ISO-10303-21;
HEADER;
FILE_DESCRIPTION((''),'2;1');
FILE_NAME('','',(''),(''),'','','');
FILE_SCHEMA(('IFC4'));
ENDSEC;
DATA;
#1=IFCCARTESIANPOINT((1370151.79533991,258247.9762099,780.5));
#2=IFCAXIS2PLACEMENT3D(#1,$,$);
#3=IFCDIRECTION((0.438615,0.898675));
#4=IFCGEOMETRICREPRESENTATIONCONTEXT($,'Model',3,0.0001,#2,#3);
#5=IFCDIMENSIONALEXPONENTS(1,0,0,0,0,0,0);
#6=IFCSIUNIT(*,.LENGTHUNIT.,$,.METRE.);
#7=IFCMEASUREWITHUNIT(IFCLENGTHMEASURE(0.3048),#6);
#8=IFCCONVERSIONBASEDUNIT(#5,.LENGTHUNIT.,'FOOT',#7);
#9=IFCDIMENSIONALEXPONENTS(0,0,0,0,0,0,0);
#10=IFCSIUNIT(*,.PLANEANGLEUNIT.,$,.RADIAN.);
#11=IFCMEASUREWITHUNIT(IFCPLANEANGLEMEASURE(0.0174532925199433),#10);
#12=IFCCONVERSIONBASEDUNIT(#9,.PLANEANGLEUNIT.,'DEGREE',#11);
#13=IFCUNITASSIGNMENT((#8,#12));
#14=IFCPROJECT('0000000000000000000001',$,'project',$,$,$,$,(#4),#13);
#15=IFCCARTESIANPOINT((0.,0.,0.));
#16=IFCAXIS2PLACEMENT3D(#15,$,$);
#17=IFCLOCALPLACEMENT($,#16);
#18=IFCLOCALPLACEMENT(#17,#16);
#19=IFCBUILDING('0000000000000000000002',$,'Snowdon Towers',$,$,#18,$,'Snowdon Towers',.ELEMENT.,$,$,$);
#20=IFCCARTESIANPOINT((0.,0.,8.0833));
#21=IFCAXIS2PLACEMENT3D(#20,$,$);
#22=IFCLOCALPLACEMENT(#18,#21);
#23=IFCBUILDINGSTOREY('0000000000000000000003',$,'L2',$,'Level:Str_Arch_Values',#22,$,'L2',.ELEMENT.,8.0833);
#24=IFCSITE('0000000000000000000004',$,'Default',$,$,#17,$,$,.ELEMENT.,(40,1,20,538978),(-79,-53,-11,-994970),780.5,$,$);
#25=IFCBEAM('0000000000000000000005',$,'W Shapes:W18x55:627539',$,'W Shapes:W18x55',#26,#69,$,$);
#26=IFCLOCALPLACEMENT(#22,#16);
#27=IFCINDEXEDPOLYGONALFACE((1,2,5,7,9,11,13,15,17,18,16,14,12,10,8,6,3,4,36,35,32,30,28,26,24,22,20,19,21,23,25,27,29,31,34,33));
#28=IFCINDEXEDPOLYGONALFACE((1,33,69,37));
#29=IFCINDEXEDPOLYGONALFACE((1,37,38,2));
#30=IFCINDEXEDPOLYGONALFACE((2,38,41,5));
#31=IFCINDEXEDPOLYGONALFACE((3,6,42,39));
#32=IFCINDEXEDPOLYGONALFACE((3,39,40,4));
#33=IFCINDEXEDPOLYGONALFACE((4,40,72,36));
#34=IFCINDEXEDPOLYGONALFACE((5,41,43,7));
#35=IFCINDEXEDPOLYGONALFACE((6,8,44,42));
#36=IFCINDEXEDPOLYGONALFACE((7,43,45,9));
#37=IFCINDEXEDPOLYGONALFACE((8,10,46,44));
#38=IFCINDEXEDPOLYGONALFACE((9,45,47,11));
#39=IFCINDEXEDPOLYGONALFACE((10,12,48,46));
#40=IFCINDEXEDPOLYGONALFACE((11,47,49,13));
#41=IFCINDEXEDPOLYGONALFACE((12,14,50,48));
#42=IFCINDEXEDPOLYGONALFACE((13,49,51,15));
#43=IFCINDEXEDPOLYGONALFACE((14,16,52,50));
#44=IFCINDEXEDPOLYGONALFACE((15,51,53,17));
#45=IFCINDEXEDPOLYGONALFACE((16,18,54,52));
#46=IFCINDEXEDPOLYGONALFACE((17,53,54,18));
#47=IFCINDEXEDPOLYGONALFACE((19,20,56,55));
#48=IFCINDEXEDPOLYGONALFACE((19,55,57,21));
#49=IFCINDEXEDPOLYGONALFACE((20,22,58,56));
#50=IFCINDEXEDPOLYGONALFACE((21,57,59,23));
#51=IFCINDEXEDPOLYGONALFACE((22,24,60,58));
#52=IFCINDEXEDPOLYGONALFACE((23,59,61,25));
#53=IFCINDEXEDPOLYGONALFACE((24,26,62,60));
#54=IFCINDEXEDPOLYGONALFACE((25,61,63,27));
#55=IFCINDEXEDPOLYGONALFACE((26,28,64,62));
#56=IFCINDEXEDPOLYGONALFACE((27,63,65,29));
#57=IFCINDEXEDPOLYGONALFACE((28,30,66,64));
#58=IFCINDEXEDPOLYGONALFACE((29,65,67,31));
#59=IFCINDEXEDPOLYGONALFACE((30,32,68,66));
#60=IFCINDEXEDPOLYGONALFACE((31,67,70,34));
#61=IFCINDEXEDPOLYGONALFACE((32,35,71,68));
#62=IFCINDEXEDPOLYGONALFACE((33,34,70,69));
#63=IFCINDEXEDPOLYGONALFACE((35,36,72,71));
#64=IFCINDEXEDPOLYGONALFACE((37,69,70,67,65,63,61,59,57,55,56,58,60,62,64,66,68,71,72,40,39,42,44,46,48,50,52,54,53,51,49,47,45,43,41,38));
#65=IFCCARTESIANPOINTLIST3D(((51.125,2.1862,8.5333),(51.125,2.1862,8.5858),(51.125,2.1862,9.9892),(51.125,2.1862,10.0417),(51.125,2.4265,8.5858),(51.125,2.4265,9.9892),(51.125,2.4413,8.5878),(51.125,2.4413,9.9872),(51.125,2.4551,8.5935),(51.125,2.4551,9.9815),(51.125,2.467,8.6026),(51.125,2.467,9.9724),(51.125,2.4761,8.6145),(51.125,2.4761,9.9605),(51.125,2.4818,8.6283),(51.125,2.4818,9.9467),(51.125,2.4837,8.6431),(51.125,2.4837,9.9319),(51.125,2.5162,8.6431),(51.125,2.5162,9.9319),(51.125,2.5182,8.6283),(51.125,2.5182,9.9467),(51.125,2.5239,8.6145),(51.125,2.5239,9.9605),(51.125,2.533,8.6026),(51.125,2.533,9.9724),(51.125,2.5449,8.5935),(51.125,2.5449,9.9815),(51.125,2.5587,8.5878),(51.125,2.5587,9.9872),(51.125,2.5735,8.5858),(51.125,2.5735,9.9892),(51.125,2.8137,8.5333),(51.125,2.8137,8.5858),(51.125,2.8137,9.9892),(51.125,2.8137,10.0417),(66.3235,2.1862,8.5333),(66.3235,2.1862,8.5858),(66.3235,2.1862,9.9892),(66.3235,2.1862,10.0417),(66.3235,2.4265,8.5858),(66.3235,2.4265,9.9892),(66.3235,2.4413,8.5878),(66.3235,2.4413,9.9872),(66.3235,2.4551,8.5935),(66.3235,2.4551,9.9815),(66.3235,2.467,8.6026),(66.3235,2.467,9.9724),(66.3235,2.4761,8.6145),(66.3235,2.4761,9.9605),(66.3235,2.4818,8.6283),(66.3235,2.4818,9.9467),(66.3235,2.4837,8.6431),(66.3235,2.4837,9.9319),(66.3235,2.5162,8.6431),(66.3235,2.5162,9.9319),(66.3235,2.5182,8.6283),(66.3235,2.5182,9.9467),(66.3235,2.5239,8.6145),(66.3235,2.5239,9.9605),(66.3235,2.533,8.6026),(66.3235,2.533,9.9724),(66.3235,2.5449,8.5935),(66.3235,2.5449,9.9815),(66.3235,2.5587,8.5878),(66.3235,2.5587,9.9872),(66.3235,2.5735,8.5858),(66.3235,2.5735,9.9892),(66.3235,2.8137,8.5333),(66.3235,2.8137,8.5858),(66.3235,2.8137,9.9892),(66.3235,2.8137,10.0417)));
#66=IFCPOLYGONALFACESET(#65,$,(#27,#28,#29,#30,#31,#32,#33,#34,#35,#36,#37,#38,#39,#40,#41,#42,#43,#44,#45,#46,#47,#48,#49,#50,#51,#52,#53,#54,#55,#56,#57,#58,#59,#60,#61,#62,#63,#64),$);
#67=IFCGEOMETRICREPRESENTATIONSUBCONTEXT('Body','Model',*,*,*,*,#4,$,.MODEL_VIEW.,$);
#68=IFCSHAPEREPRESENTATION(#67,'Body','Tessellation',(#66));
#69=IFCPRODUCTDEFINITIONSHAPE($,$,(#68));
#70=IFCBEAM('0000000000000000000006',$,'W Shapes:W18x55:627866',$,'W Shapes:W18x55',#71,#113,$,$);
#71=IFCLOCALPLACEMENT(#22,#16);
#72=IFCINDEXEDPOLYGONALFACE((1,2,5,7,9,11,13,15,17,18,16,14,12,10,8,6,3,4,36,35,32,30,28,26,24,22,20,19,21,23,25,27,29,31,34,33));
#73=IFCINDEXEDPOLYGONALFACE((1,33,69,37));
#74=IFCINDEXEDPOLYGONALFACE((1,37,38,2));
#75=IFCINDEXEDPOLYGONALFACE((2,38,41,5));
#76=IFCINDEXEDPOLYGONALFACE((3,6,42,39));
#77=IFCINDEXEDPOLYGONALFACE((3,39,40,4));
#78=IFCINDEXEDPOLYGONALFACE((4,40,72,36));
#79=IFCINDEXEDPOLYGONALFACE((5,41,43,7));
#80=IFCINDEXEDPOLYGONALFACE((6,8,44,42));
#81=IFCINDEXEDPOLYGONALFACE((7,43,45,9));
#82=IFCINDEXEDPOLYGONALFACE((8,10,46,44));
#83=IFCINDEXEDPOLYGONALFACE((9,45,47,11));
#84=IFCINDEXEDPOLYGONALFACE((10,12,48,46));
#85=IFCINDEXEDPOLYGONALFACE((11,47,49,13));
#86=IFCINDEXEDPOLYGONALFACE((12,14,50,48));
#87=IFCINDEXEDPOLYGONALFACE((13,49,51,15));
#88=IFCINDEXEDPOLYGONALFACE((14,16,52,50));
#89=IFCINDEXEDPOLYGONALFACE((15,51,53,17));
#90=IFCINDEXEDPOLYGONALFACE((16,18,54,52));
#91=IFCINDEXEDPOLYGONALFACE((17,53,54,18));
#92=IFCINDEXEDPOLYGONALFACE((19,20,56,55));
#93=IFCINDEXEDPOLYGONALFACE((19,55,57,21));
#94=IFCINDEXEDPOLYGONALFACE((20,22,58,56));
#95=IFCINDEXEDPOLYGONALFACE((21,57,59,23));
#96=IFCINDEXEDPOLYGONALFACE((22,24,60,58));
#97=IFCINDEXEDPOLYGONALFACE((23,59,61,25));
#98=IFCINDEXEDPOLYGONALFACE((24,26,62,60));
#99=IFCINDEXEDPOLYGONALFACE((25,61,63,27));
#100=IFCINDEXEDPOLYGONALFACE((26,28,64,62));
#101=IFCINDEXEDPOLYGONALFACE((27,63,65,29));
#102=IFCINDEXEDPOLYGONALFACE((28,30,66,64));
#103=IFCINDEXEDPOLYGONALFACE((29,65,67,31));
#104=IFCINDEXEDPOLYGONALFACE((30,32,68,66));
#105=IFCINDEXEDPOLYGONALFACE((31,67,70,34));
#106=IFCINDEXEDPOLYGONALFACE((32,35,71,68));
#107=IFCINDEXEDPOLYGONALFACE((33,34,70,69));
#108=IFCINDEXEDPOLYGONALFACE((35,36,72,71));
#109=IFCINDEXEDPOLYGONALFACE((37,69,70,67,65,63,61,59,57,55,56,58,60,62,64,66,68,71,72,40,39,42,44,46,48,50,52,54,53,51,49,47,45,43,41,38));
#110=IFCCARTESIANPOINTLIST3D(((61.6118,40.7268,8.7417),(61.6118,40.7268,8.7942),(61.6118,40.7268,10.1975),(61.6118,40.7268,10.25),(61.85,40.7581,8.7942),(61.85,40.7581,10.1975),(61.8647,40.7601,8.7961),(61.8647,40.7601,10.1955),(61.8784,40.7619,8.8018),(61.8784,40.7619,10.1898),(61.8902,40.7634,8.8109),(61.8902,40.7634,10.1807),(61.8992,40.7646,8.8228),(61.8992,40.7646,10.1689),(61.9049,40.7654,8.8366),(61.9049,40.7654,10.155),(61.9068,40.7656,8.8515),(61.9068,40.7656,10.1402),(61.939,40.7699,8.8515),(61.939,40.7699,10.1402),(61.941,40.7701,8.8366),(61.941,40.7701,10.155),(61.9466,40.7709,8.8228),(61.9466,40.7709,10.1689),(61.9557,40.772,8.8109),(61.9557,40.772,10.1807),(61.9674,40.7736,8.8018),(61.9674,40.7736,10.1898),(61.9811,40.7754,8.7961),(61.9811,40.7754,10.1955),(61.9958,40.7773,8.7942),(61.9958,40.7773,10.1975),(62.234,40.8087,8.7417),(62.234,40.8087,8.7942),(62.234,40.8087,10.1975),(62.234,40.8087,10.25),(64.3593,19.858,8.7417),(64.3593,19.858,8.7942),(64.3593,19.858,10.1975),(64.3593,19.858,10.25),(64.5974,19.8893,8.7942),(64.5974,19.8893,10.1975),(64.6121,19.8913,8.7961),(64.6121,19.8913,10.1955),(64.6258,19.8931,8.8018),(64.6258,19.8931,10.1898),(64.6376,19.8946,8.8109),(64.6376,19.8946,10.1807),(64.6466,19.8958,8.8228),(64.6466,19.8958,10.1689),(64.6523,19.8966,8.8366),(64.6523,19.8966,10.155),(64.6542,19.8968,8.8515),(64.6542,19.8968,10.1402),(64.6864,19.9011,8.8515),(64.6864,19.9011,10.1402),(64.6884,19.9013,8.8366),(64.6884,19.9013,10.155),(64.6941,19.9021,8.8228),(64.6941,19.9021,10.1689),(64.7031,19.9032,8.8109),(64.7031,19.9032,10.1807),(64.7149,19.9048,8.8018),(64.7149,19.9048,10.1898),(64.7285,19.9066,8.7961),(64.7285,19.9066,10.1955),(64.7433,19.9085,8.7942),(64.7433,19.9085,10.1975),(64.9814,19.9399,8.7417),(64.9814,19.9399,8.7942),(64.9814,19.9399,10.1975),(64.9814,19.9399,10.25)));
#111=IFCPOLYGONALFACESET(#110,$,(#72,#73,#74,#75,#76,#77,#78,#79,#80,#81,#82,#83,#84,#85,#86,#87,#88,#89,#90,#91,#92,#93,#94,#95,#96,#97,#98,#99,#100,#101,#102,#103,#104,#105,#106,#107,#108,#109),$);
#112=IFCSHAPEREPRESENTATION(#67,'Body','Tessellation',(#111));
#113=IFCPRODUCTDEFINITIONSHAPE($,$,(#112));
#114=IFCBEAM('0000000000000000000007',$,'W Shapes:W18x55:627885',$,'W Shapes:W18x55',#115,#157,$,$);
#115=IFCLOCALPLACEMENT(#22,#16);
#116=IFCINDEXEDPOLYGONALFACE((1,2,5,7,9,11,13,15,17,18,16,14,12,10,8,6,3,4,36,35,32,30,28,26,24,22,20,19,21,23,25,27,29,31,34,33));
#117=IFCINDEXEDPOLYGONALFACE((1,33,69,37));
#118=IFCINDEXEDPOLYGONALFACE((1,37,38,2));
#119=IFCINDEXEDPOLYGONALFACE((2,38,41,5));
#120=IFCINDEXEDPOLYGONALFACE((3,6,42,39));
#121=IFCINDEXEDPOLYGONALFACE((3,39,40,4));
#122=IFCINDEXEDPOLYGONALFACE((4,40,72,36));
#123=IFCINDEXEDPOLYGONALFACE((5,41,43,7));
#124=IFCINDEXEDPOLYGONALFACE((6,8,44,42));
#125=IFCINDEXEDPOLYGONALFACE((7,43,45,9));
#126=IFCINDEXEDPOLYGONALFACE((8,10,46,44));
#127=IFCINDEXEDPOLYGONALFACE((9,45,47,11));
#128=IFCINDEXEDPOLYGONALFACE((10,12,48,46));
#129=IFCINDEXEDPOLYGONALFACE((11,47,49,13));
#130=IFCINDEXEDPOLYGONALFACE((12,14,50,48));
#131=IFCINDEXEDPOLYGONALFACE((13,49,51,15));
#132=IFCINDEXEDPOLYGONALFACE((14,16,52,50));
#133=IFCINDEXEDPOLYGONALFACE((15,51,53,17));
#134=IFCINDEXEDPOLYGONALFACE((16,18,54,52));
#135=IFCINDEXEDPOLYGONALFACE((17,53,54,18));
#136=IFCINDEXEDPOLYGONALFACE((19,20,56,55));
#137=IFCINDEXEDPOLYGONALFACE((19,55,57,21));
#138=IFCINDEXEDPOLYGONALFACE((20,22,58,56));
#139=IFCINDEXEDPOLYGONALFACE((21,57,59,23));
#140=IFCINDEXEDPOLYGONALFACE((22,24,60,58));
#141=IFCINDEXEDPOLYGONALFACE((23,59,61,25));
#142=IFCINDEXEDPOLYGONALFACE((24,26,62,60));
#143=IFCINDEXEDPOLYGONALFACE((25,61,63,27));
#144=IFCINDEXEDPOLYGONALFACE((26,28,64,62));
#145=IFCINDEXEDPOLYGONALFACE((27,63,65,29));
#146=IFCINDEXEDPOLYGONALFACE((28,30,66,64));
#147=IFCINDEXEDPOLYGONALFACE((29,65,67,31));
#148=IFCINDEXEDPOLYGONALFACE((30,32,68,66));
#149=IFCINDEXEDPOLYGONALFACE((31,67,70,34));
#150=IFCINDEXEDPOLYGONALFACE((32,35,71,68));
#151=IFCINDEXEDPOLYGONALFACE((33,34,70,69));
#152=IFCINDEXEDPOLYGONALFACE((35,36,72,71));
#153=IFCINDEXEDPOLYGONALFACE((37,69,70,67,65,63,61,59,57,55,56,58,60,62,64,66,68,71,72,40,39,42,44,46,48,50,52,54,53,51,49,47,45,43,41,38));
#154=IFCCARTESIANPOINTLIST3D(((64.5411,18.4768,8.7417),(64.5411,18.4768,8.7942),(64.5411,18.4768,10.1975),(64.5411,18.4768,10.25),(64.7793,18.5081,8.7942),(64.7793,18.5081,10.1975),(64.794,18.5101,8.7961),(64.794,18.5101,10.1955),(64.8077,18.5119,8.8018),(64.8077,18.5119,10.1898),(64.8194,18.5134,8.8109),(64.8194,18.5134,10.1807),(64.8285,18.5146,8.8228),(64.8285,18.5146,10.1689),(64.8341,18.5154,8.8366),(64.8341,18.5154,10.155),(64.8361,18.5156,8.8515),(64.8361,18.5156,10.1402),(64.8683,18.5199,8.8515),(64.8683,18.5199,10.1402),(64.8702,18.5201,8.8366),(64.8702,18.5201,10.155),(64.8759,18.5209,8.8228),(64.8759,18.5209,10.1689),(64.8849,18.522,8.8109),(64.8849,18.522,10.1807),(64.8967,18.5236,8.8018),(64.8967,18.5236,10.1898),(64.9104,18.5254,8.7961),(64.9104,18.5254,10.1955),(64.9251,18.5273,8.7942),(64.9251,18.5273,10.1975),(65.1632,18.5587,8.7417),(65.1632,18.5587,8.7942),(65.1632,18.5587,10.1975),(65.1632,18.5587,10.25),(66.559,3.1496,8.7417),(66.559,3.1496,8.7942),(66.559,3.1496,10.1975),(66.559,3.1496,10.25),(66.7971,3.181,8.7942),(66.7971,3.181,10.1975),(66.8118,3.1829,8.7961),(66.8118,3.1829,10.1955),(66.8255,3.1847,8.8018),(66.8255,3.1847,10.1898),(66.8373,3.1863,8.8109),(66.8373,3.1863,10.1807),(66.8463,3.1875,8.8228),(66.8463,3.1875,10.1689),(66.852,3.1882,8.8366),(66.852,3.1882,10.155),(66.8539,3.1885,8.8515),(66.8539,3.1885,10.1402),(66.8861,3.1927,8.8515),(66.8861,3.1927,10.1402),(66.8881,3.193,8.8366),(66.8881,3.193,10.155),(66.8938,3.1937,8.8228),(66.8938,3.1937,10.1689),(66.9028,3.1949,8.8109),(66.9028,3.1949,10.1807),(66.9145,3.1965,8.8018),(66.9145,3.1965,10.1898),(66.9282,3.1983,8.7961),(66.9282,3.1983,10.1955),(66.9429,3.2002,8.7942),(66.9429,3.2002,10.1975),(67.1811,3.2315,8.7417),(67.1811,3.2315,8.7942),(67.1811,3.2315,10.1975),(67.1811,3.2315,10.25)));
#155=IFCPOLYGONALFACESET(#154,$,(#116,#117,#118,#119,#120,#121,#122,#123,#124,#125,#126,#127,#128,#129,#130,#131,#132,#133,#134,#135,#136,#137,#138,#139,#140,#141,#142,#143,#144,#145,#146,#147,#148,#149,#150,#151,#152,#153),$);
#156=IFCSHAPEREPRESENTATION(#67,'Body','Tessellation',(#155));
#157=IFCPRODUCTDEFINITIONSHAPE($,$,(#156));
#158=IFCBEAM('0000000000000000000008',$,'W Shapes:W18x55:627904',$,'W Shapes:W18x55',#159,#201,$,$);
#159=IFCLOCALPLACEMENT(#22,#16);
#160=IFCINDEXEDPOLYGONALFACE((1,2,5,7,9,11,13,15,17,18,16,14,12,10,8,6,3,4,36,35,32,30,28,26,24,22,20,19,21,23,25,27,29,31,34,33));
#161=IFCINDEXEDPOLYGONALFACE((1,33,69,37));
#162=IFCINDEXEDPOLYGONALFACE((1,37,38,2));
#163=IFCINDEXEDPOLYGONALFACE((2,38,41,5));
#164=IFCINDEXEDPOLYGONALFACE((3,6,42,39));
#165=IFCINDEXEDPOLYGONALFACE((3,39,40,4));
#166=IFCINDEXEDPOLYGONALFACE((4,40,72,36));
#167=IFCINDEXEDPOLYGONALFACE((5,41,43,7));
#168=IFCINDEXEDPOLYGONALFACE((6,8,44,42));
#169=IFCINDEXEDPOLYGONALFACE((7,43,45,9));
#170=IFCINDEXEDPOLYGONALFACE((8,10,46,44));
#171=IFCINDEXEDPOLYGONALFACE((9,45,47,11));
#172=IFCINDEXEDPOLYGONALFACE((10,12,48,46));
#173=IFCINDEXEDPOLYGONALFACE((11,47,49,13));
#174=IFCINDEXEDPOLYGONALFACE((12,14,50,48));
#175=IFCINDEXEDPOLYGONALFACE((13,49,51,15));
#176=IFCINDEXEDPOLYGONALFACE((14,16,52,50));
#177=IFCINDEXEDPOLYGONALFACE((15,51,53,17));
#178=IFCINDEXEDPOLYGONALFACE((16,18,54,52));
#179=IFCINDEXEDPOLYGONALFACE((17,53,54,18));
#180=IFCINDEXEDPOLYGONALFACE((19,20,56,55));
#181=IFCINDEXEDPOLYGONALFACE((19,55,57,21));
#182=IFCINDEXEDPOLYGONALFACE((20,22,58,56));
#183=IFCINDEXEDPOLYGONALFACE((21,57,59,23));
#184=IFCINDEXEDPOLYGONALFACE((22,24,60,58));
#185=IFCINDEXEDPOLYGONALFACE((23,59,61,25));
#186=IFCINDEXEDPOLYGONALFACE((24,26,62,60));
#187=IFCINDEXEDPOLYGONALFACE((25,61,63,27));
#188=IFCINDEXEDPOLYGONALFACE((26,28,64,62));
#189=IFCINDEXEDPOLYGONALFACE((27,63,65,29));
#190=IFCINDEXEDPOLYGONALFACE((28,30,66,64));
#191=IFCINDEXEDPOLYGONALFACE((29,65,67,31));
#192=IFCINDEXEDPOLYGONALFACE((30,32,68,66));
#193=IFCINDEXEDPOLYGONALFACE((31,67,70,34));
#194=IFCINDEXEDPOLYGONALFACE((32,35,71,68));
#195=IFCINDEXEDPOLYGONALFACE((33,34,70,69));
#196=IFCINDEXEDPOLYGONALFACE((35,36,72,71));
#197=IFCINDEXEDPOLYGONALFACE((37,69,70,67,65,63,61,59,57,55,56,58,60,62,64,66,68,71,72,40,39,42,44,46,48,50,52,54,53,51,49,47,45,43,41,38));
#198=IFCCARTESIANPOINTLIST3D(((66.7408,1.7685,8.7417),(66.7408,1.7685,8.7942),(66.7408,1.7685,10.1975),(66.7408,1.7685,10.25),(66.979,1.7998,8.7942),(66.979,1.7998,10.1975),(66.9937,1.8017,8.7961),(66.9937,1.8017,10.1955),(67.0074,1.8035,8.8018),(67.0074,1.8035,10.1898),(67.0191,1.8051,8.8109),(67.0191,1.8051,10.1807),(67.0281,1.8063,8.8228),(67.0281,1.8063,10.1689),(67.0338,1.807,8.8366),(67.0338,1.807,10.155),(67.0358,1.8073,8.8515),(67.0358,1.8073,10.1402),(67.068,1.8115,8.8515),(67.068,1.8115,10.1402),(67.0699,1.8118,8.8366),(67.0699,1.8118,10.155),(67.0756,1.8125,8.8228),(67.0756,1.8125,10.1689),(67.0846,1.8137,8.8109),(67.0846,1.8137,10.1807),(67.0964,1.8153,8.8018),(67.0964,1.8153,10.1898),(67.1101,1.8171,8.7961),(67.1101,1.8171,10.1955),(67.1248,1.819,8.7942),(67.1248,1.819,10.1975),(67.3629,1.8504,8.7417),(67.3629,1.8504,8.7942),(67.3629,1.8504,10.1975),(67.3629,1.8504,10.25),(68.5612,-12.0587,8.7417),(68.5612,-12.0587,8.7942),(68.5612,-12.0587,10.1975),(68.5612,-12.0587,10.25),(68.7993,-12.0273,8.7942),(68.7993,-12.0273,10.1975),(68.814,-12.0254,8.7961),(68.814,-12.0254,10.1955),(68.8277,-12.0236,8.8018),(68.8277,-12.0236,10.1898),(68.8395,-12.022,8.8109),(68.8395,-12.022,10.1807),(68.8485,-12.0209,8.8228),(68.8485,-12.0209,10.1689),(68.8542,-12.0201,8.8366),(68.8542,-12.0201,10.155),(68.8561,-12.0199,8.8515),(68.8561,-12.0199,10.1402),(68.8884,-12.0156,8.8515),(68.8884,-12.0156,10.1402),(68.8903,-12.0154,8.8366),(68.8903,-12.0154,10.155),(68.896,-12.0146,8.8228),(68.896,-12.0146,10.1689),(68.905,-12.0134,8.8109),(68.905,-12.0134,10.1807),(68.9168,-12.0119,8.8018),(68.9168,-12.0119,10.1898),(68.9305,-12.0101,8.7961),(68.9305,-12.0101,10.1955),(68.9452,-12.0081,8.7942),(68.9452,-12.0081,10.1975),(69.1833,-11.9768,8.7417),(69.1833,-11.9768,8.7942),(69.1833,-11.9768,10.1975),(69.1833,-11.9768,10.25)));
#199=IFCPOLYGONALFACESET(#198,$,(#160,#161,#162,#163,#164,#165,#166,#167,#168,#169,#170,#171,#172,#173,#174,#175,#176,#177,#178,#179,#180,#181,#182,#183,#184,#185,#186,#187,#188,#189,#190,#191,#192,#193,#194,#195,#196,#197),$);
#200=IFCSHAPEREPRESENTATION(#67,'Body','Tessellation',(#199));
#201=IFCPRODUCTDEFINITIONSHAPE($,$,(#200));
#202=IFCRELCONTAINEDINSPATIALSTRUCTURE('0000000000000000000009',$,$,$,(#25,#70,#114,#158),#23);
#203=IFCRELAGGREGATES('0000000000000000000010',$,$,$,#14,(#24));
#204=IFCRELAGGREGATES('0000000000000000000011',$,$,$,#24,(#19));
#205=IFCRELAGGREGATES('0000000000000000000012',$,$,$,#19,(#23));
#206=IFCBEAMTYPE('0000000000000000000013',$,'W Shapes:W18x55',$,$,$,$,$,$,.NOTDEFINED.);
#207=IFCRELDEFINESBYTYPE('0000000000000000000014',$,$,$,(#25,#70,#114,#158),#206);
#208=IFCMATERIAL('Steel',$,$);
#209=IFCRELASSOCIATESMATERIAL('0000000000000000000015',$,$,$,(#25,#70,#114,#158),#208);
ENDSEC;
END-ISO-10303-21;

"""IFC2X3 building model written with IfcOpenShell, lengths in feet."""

from ifc_helpers import new_model, entity, si_unit, converted_unit, direction, frame, frame_2d, origin, place, context, subcontext, project, spatial, i_section, extrude, material, type_object, element, save


model = new_model("IFC2X3")

# Units and contexts
model_context = context("Model", 3, precision=0.0001, world=frame((1370151.79533991, 258247.9762099, 780.5)), true_north=direction((0.438615, 0.898675)))
body_context = subcontext(model_context, "Body", "Model", "MODEL_VIEW")
ifc_project = project(units=[converted_unit("LENGTHUNIT", "FOOT", entity("IfcLengthMeasure", 0.3048), si_unit("LENGTHUNIT", "METRE"), dimensions=[1, 0, 0, 0, 0, 0, 0]), converted_unit("PLANEANGLEUNIT", "DEGREE", entity("IfcPlaneAngleMeasure", 0.0174532925199433), si_unit("PLANEANGLEUNIT", "RADIAN"), dimensions=[0, 0, 0, 0, 0, 0, 0])], contexts=[model_context])

# Site, building, storey
site_placement = place(None, origin())
site = spatial("IfcSite", under=ifc_project, at=site_placement, Name="Default", CompositionType="ELEMENT", RefLatitude=(40, 1, 20, 538978), RefLongitude=(-79, -53, -11, -994970), RefElevation=780.5)
building_placement = place(site_placement, origin())
building = spatial("IfcBuilding", under=site, at=building_placement, Name="Snowdon Towers", LongName="Snowdon Towers", CompositionType="ELEMENT")
storey_placement = place(building_placement, frame((0.0, 0.0, 8.0833)))
storey = spatial("IfcBuildingStorey", under=building, at=storey_placement, Name="L2", ObjectType="Level:Str_Arch_Values", LongName="L2", CompositionType="ELEMENT", Elevation=8.0833)

# Beams
ifc_material = material(Name="Steel")
beam_type_1 = type_object("IfcBeamType", Name="W Shapes:W18x55", PredefinedType="NOTDEFINED")
beam_1_placement = place(storey_placement, frame((51.125, 2.5, 10.25)))
element("IfcBeam", 1, at=beam_1_placement, inside=storey, type_object=beam_type_1, material=ifc_material, Name="W Shapes:W18x55:627539", ObjectType="W Shapes:W18x55", context=body_context, shape_type="SweptSolid", body=[
    extrude(i_section(OverallWidth=0.6275, OverallDepth=1.5083, WebThickness=0.0325, FlangeThickness=0.0525, FilletRadius=0.0573, at=frame_2d((0.0, 0.0), x_axis=(0.0, 1.0))), frame((0.0, 0.0, -0.9625), z_axis=(1.0, 0.0, 0.0), x_axis=(0.0, 0.0, -1.0)), (0.0, 0.0, 1.0), 15.1985),
])
beam_2_placement = place(storey_placement, frame((61.8201, 41.5489, 10.25), z_axis=(0.0, 0.0, 1.0), x_axis=(0.130526, -0.991445, 0.0)))
element("IfcBeam", 2, at=beam_2_placement, inside=storey, type_object=beam_type_1, material=ifc_material, Name="W Shapes:W18x55:627866", ObjectType="W Shapes:W18x55", context=body_context, shape_type="SweptSolid", body=[
    extrude(i_section(OverallWidth=0.6275, OverallDepth=1.5083, WebThickness=0.0325, FlangeThickness=0.0525, FilletRadius=0.0573, at=frame_2d((0.0, 0.0), x_axis=(0.0, 1.0))), frame((0.7879, 0.0, -0.7542), z_axis=(1.0, 0.0, 0.0), x_axis=(0.0, 0.0, -1.0)), (0.0, 0.0, 1.0), 21.0489),
])
beam_3_placement = place(storey_placement, frame((64.7713, 19.1322, 10.25), z_axis=(0.0, 0.0, 1.0), x_axis=(0.130526, -0.991445, 0.0)))
element("IfcBeam", 3, at=beam_3_placement, inside=storey, type_object=beam_type_1, material=ifc_material, Name="W Shapes:W18x55:627885", ObjectType="W Shapes:W18x55", context=body_context, shape_type="SweptSolid", body=[
    extrude(i_section(OverallWidth=0.6275, OverallDepth=1.5083, WebThickness=0.0325, FlangeThickness=0.0525, FilletRadius=0.0573, at=frame_2d((0.0, 0.0), x_axis=(0.0, 1.0))), frame((0.6198, 0.0, -0.7542), z_axis=(1.0, 0.0, 0.0), x_axis=(0.0, 0.0, -1.0)), (0.0, 0.0, 1.0), 15.4594),
])
beam_4_placement = place(storey_placement, frame((66.971, 2.4239, 10.25), z_axis=(0.0, 0.0, 1.0), x_axis=(0.130526, -0.991445, 0.0)))
element("IfcBeam", 4, at=beam_4_placement, inside=storey, type_object=beam_type_1, material=ifc_material, Name="W Shapes:W18x55:627904", ObjectType="W Shapes:W18x55", context=body_context, shape_type="SweptSolid", body=[
    extrude(i_section(OverallWidth=0.6275, OverallDepth=1.5083, WebThickness=0.0325, FlangeThickness=0.0525, FilletRadius=0.0573, at=frame_2d((0.0, 0.0), x_axis=(0.0, 1.0))), frame((0.6198, 0.0, -0.7542), z_axis=(1.0, 0.0, 0.0), x_axis=(0.0, 0.0, -1.0)), (0.0, 0.0, 1.0), 13.9465),
])

save(model, "model.ifc")
